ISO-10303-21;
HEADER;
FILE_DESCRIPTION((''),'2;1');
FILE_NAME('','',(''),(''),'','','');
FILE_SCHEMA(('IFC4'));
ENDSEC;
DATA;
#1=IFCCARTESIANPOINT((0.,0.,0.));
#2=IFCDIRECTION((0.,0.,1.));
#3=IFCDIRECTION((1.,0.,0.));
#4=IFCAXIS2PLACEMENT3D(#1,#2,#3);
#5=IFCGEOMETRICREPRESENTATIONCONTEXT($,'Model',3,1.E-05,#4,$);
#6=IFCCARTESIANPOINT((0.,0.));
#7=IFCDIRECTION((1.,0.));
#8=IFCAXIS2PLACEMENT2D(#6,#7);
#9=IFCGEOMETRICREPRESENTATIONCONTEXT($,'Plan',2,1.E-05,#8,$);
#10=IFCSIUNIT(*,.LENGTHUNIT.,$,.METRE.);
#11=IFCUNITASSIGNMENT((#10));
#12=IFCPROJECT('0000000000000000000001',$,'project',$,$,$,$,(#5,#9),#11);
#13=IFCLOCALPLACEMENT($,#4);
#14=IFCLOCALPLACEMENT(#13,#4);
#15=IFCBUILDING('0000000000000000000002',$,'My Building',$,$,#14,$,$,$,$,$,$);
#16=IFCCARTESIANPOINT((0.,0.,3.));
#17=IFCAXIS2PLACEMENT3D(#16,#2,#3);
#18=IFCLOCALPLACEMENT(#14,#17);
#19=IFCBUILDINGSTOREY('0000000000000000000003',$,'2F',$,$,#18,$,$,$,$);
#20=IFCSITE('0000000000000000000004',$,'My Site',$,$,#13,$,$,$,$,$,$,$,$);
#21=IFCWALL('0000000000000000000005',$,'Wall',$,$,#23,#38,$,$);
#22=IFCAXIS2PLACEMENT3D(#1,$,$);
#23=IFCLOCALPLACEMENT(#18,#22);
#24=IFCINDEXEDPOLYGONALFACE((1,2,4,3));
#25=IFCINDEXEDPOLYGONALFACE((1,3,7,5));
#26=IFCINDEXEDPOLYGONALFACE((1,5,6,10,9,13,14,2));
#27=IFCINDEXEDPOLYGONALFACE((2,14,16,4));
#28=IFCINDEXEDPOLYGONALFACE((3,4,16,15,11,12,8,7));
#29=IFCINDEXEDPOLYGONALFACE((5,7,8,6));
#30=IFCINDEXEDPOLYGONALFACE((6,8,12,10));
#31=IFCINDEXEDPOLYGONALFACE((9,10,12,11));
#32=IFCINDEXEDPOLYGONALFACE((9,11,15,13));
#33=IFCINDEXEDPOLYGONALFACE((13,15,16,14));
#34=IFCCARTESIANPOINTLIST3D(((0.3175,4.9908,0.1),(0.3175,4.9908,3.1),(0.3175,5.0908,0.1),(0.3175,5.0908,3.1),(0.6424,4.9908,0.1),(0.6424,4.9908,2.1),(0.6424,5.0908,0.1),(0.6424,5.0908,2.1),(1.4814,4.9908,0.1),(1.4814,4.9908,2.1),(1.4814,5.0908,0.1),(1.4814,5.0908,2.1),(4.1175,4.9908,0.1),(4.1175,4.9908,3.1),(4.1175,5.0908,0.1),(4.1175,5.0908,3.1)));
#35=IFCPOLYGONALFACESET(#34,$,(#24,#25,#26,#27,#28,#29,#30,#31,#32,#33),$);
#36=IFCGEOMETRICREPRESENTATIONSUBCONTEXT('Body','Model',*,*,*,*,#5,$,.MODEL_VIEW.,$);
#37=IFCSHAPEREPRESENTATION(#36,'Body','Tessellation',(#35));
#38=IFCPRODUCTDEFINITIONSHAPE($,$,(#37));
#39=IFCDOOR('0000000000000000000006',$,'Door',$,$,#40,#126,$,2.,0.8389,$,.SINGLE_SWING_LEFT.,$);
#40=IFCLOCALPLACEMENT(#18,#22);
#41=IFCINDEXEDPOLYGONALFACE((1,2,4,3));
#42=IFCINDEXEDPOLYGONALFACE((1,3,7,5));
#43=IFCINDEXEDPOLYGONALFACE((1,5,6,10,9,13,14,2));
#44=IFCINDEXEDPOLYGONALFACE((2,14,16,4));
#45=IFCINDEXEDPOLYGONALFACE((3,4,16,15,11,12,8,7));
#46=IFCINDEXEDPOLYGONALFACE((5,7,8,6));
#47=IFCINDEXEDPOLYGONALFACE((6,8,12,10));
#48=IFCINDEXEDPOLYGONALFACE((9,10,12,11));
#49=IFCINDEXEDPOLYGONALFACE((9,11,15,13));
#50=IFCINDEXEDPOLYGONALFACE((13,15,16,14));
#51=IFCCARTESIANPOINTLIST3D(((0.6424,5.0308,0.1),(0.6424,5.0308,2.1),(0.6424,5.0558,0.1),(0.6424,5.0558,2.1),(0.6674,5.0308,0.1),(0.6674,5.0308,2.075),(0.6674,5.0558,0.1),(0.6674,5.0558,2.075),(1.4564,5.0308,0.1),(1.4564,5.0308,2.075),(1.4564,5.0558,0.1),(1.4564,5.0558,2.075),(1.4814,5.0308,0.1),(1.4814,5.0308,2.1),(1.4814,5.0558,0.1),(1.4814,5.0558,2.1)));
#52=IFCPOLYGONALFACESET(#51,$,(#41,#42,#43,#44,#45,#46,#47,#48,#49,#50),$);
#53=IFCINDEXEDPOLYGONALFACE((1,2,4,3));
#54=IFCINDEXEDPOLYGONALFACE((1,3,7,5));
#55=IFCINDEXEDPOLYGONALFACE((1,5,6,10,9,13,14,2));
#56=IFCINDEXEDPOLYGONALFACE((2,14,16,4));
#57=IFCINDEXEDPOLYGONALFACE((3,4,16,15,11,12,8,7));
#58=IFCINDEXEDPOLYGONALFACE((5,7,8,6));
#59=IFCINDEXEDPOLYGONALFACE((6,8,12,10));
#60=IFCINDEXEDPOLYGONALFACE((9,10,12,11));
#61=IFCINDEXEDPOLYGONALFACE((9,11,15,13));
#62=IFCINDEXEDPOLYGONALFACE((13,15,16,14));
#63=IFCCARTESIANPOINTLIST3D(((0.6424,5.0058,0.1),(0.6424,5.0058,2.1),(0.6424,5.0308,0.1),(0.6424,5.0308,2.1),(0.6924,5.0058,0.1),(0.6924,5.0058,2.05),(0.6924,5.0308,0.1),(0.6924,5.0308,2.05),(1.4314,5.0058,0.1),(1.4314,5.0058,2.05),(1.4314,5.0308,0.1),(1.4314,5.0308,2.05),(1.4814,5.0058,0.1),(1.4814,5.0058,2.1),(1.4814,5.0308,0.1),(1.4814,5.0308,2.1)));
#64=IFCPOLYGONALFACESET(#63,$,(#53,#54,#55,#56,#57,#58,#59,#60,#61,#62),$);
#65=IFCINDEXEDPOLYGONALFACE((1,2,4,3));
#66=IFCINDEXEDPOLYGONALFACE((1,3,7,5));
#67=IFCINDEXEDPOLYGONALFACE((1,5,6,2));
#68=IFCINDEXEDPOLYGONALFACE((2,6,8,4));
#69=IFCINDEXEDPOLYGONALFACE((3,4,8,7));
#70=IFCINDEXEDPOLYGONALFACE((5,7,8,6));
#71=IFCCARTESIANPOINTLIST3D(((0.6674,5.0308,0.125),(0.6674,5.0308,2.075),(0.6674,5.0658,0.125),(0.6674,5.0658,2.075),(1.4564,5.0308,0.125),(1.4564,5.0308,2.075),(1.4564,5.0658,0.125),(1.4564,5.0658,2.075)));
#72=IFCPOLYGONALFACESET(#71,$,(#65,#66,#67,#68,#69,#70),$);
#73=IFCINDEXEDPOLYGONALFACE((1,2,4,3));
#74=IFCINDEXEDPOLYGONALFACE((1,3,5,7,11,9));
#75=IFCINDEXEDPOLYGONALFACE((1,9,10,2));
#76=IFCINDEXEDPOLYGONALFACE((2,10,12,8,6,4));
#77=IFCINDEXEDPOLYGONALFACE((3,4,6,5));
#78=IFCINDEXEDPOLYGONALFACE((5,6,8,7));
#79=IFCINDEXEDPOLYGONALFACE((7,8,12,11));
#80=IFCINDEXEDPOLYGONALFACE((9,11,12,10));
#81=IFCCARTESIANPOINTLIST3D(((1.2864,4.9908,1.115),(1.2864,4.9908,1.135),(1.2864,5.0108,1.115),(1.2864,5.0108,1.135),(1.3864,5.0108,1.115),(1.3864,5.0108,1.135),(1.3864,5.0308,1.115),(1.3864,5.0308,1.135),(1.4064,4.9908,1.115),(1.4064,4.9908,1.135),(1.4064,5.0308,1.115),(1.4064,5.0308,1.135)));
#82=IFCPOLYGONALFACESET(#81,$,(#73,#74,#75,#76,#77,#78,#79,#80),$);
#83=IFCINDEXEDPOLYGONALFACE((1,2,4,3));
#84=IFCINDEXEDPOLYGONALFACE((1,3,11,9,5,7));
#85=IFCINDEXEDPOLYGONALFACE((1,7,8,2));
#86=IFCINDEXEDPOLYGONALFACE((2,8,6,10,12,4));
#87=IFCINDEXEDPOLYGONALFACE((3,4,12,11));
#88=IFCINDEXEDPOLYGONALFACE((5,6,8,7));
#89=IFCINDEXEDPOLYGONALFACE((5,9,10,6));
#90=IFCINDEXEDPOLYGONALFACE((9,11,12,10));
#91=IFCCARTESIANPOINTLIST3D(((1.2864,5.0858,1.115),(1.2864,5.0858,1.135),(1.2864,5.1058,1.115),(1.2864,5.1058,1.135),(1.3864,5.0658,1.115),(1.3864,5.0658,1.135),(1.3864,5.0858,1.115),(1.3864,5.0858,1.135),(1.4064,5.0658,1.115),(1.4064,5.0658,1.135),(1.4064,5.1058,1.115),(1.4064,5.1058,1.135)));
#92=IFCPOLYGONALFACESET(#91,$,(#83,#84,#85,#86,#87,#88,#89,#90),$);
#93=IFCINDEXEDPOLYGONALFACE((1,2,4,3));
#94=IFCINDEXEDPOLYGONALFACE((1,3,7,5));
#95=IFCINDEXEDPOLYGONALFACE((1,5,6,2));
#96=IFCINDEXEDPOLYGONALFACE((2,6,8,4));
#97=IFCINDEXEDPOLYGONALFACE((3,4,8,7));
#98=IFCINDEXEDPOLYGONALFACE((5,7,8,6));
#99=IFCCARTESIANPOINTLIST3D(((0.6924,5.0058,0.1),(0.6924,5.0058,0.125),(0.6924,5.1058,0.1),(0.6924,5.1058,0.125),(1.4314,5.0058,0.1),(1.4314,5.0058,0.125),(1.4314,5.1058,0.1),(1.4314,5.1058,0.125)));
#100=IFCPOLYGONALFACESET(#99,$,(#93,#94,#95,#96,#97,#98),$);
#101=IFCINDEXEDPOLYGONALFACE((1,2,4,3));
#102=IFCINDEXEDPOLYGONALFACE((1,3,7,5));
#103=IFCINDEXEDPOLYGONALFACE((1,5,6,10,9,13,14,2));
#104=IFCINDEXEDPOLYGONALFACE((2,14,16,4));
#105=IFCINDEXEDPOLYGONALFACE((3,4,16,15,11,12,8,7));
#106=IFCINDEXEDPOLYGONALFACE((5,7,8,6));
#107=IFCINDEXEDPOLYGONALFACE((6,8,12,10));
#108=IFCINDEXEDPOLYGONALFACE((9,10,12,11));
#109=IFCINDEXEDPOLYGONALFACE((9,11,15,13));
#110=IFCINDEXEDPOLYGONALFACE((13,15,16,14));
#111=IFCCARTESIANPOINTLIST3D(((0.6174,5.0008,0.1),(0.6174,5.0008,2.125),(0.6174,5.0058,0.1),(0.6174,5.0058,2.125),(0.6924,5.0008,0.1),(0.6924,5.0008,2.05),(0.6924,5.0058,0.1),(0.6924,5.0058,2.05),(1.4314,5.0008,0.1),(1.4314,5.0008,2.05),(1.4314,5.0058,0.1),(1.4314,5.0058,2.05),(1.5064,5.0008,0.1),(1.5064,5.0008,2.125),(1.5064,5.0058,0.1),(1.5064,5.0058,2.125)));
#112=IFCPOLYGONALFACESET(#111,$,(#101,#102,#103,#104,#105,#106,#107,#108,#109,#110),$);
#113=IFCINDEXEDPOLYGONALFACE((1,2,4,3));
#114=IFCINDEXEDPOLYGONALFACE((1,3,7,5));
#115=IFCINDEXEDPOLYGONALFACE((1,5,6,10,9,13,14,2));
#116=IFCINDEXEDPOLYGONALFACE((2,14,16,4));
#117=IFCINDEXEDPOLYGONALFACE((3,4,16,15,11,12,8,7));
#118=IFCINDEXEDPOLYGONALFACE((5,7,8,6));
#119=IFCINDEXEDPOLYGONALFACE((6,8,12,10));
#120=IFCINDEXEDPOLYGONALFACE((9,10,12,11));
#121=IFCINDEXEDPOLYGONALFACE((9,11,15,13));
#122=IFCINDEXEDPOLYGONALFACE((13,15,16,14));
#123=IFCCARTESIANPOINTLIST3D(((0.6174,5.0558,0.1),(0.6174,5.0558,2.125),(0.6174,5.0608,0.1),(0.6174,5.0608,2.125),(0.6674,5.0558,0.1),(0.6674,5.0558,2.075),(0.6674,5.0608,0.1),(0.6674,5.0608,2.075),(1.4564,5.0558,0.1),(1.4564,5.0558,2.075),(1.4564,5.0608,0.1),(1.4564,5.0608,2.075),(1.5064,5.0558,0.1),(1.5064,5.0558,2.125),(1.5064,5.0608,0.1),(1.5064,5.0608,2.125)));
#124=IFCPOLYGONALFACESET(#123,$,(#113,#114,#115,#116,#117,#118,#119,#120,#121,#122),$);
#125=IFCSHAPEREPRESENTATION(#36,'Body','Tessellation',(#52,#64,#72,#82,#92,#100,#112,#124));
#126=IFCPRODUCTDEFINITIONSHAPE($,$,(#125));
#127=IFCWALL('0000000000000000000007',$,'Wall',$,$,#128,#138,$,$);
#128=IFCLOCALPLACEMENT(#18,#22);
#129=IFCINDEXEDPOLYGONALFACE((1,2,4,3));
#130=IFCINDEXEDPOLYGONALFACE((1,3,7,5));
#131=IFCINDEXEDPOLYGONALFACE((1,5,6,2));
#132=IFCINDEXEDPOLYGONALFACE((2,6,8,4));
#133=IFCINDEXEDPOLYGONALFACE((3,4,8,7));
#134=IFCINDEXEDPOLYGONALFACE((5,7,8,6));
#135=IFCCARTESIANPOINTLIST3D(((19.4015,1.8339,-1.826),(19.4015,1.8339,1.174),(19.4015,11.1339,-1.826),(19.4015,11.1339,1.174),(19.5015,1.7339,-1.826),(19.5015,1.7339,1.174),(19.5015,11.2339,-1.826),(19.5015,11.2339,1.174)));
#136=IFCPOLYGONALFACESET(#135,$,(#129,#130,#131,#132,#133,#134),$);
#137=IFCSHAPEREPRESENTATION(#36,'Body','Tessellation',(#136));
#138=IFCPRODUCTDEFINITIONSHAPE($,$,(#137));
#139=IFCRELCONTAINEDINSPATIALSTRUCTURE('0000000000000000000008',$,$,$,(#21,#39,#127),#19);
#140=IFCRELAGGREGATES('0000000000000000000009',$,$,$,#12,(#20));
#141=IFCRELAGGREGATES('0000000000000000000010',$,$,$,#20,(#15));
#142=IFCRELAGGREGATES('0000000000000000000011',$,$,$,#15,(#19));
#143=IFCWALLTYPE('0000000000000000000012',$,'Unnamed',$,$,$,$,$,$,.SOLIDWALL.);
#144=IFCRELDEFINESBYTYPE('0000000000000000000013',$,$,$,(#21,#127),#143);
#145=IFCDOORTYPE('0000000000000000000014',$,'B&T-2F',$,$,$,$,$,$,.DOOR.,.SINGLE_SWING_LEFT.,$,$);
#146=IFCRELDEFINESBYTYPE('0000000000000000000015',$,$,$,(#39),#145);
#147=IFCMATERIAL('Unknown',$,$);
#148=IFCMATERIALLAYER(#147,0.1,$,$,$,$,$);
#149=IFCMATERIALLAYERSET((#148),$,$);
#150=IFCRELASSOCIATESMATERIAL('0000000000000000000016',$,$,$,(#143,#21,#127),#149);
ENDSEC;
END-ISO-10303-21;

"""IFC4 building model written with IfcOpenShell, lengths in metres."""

from ifc_helpers import new_model, entity, si_unit, frame, origin_with_axes, origin_2d_with_axis, place, context, subcontext, project, spatial, line, indexed_curve, outline, extrude, shape, source, transform, mapped, material, layer, layer_set, layer_usage, type_object, type_shapes, element, fill, save


model = new_model("IFC4")

# Units and contexts
model_context = context("Model", 3, precision=1e-05, world=origin_with_axes())
plan_context = context("Plan", 2, precision=1e-05, world=origin_2d_with_axis())
body_context_1 = subcontext(model_context, "Body", "Model", "MODEL_VIEW")
body_context_2 = subcontext(plan_context, "Body", "Plan", "PLAN_VIEW")
ifc_project = project(units=[si_unit("LENGTHUNIT", "METRE")], contexts=[model_context, plan_context])

# Site, building, storey
site_placement = place(None, origin_with_axes())
site = spatial("IfcSite", under=ifc_project, at=site_placement, Name="My Site")
building_placement = place(site_placement, origin_with_axes())
building = spatial("IfcBuilding", under=site, at=building_placement, Name="My Building")
storey_placement = place(building_placement, frame((0.0, 0.0, 3.0), z_axis=(0.0, 0.0, 1.0), x_axis=(1.0, 0.0, 0.0)))
storey = spatial("IfcBuildingStorey", under=building, at=storey_placement, Name="2F")

# Shared definitions
ifc_material = material(Name="Unknown")
ifc_layer = layer(ifc_material, 0.1)
ifc_layer_set = layer_set([ifc_layer])
wall_type = type_object("IfcWallType", Name="Unnamed", PredefinedType="SOLIDWALL", material=ifc_layer_set)

# Wall, opening, door
ifc_layer_usage_1 = layer_usage(ifc_layer_set, "AXIS2", "POSITIVE", 0.0)
wall_1_placement = place(storey_placement, frame((4.1175, 5.0908, 0.1), z_axis=(0.0, 0.0, 1.0), x_axis=(-1.0, 0.0, 0.0)))
wall_1 = element("IfcWall", 1, at=wall_1_placement, inside=storey, type_object=wall_type, material=ifc_layer_usage_1, Name="Wall", context=body_context_1, shape_type="SweptSolid", body=[
    extrude(outline(indexed_curve([(0.0, 0.0), (0.0, 0.1), (3.8, 0.1), (3.8, 0.0)], segments=[line(1, 2, 3, 4, 1)])), origin_with_axes(), (0.0, 0.0, 1.0), 3.0),
])
shared_shape_1 = source(origin_with_axes(), body_context_1, "Body", "SweptSolid", [
    extrude(outline(indexed_curve([(0.0, 0.0), (0.8389, 0.0), (0.8389, 2.0), (0.0, 2.0)], segments=[line(1, 2, 3, 4, 1)])), frame((0.0, -0.6, 0.0), z_axis=(0.0, -1.0, 0.0), x_axis=(1.0, 0.0, 0.0)), (0.0, 0.0, -1.0), 1.2),
])
opening_1_placement = place(wall_1_placement, frame((3.4751, 0.085, 0.0), z_axis=(0.0, 0.0, 1.0), x_axis=(-1.0, 0.0, 0.0)))
opening_1 = element("IfcOpeningElement", 2, at=opening_1_placement, cuts=wall_1, PredefinedType="OPENING", context=body_context_1, shape_type="MappedRepresentation", body=[
    mapped(shared_shape_1, transform((0.0, 0.0, 0.0), x_axis=(1.0, 0.0, 0.0), y_axis=(0.0, 1.0, 0.0), z_axis=(0.0, 0.0, 1.0), scale=1.0)),
])
door_type_1 = type_object("IfcDoorType", Name="B&T-2F", OperationType="SINGLE_SWING_LEFT", PredefinedType="DOOR")
shared_shape_2 = source(origin_with_axes(), body_context_1, "Body", "SweptSolid", [
    extrude(outline(indexed_curve([(0.0, 0.0), (0.0, 2.0), (0.8389, 2.0), (0.8389, 0.0), (0.8139, 0.0), (0.8139, 1.975), (0.025, 1.975), (0.025, 0.0)], segments=[line(1, 2, 3, 4, 5, 6, 7, 8, 1)])), frame((0.0, 0.025, 0.0), z_axis=(0.0, -1.0, 0.0), x_axis=(1.0, 0.0, 0.0)), (0.0, 0.0, -1.0), 0.025),
    extrude(outline(indexed_curve([(0.0, 0.0), (0.0, 2.0), (0.8389, 2.0), (0.8389, 0.0), (0.7889, 0.0), (0.7889, 1.95), (0.05, 1.95), (0.05, 0.0)], segments=[line(1, 2, 3, 4, 5, 6, 7, 8, 1)])), frame((0.0, 0.0, 0.0), z_axis=(0.0, -1.0, 0.0), x_axis=(1.0, 0.0, 0.0)), (0.0, 0.0, -1.0), 0.025),
    extrude(outline(indexed_curve([(0.0, 0.0), (0.7889, 0.0), (0.7889, 0.035), (0.0, 0.035)], segments=[line(1, 2, 3, 4, 1)])), frame((0.025, 0.025, 0.025), z_axis=(0.0, 0.0, 1.0), x_axis=(1.0, 0.0, 0.0)), (0.0, 0.0, 1.0), 1.95),
    extrude(outline(indexed_curve([(0.0, 0.0), (0.0, -0.04), (-0.12, -0.04), (-0.12, -0.02), (-0.02, -0.02), (-0.02, 0.0)], segments=[line(1, 2, 3, 4, 5, 6, 1)])), frame((0.7639, 0.025, 1.015), z_axis=(0.0, 0.0, 1.0), x_axis=(1.0, 0.0, 0.0)), (0.0, 0.0, 1.0), 0.02),
    extrude(outline(indexed_curve([(0.0, 0.0), (0.0, 0.04), (-0.12, 0.04), (-0.12, 0.02), (-0.02, 0.02), (-0.02, 0.0)], segments=[line(1, 2, 3, 4, 5, 6, 1)])), frame((0.7639, 0.06, 1.015), z_axis=(0.0, 0.0, 1.0), x_axis=(1.0, 0.0, 0.0)), (0.0, 0.0, 1.0), 0.02),
    extrude(outline(indexed_curve([(0.0, 0.0), (0.7389, 0.0), (0.7389, 0.1), (0.0, 0.1)], segments=[line(1, 2, 3, 4, 1)])), frame((0.05, 0.0, 0.0), z_axis=(0.0, 0.0, 1.0), x_axis=(1.0, 0.0, 0.0)), (0.0, 0.0, 1.0), 0.025),
    extrude(outline(indexed_curve([(0.0, 0.0), (0.0, 2.025), (0.8889, 2.025), (0.8889, 0.0), (0.8139, 0.0), (0.8139, 1.95), (0.075, 1.95), (0.075, 0.0)], segments=[line(1, 2, 3, 4, 5, 6, 7, 8, 1)])), frame((-0.025, -0.005, 0.0), z_axis=(0.0, -1.0, 0.0), x_axis=(1.0, 0.0, 0.0)), (0.0, 0.0, -1.0), 0.005),
    extrude(outline(indexed_curve([(0.0, 0.0), (0.0, 2.025), (0.8889, 2.025), (0.8889, 0.0), (0.8389, 0.0), (0.8389, 1.975), (0.05, 1.975), (0.05, 0.0)], segments=[line(1, 2, 3, 4, 5, 6, 7, 8, 1)])), frame((-0.025, 0.05, 0.0), z_axis=(0.0, -1.0, 0.0), x_axis=(1.0, 0.0, 0.0)), (0.0, 0.0, -1.0), 0.005),
])
shared_shape_3 = source(origin_with_axes(), body_context_2, "Body", "Curve2D", [
    entity("IfcIndexedPolyCurve", entity("IfcCartesianPointList2D", [[0.0, 0.0], [0.0, 0.05], [0.025, 0.05], [0.025, 0.025], [0.05, 0.025], [0.05, 0.0]]), [entity("IfcLineIndex", [1, 2, 3, 4, 5, 6, 1])]),
    entity("IfcIndexedPolyCurve", entity("IfcCartesianPointList2D", [[0.8389, 0.0], [0.8389, 0.05], [0.8139, 0.05], [0.8139, 0.025], [0.7889, 0.025], [0.7889, 0.0]]), [entity("IfcLineIndex", [1, 2, 3, 4, 5, 6, 1])]),
    entity("IfcTrimmedCurve", entity("IfcEllipse", entity("IfcAxis2Placement2D", entity("IfcCartesianPoint", [0.06, 0.05]), entity("IfcDirection", [1.0, 0.0])), 0.7539, 0.7889), [entity("IfcCartesianPoint", [0.8139, 0.05])], [entity("IfcCartesianPoint", [0.06, 0.8389])], True, "CARTESIAN"),
    entity("IfcIndexedPolyCurve", entity("IfcCartesianPointList2D", [[0.025, 0.05], [0.06, 0.05], [0.06, 0.8389], [0.025, 0.8389]]), [entity("IfcLineIndex", [1, 2, 3, 4, 1])]),
])
type_shapes(door_type_1, [shared_shape_2, shared_shape_3])
door_1_placement = place(opening_1_placement, frame((0.0, 0.0, 0.0), z_axis=(0.0, 0.0, 1.0), x_axis=(1.0, 0.0, 0.0)))
door_1 = element("IfcDoor", 3, at=door_1_placement, inside=storey, type_object=door_type_1, Name="Door", OperationType="SINGLE_SWING_LEFT", OverallHeight=2.0, OverallWidth=0.8389, shapes=[
    shape(body_context_1, "Body", "MappedRepresentation", [mapped(shared_shape_2, transform((0.0, 0.0, 0.0), x_axis=(1.0, 0.0, 0.0), y_axis=(0.0, 1.0, 0.0), z_axis=(0.0, 0.0, 1.0), scale=1.0))]),
    shape(body_context_2, "Body", "MappedRepresentation", [mapped(shared_shape_3, transform((0.0, 0.0, 0.0), x_axis=(1.0, 0.0, 0.0), y_axis=(0.0, 1.0, 0.0), z_axis=(0.0, 0.0, 1.0), scale=1.0))]),
])
fill(opening_1, door_1)

# Wall
ifc_layer_usage_2 = layer_usage(ifc_layer_set, "AXIS2", "POSITIVE", 0.0)
wall_2_placement = place(storey_placement, frame((19.4015, 11.1339, -1.826), z_axis=(0.0, 0.0, 1.0), x_axis=(0.0, -1.0, 0.0)))
element("IfcWall", 4, at=wall_2_placement, inside=storey, type_object=wall_type, material=ifc_layer_usage_2, Name="Wall", context=body_context_1, shape_type="SweptSolid", body=[
    extrude(outline(indexed_curve([(0.0, 0.0), (-0.1, 0.1), (9.4, 0.1), (9.3, 0.0)], segments=[line(1, 2, 3, 4, 1)])), origin_with_axes(), (0.0, 0.0, 1.0), 3.0),
])

save(model, "model.ifc")
